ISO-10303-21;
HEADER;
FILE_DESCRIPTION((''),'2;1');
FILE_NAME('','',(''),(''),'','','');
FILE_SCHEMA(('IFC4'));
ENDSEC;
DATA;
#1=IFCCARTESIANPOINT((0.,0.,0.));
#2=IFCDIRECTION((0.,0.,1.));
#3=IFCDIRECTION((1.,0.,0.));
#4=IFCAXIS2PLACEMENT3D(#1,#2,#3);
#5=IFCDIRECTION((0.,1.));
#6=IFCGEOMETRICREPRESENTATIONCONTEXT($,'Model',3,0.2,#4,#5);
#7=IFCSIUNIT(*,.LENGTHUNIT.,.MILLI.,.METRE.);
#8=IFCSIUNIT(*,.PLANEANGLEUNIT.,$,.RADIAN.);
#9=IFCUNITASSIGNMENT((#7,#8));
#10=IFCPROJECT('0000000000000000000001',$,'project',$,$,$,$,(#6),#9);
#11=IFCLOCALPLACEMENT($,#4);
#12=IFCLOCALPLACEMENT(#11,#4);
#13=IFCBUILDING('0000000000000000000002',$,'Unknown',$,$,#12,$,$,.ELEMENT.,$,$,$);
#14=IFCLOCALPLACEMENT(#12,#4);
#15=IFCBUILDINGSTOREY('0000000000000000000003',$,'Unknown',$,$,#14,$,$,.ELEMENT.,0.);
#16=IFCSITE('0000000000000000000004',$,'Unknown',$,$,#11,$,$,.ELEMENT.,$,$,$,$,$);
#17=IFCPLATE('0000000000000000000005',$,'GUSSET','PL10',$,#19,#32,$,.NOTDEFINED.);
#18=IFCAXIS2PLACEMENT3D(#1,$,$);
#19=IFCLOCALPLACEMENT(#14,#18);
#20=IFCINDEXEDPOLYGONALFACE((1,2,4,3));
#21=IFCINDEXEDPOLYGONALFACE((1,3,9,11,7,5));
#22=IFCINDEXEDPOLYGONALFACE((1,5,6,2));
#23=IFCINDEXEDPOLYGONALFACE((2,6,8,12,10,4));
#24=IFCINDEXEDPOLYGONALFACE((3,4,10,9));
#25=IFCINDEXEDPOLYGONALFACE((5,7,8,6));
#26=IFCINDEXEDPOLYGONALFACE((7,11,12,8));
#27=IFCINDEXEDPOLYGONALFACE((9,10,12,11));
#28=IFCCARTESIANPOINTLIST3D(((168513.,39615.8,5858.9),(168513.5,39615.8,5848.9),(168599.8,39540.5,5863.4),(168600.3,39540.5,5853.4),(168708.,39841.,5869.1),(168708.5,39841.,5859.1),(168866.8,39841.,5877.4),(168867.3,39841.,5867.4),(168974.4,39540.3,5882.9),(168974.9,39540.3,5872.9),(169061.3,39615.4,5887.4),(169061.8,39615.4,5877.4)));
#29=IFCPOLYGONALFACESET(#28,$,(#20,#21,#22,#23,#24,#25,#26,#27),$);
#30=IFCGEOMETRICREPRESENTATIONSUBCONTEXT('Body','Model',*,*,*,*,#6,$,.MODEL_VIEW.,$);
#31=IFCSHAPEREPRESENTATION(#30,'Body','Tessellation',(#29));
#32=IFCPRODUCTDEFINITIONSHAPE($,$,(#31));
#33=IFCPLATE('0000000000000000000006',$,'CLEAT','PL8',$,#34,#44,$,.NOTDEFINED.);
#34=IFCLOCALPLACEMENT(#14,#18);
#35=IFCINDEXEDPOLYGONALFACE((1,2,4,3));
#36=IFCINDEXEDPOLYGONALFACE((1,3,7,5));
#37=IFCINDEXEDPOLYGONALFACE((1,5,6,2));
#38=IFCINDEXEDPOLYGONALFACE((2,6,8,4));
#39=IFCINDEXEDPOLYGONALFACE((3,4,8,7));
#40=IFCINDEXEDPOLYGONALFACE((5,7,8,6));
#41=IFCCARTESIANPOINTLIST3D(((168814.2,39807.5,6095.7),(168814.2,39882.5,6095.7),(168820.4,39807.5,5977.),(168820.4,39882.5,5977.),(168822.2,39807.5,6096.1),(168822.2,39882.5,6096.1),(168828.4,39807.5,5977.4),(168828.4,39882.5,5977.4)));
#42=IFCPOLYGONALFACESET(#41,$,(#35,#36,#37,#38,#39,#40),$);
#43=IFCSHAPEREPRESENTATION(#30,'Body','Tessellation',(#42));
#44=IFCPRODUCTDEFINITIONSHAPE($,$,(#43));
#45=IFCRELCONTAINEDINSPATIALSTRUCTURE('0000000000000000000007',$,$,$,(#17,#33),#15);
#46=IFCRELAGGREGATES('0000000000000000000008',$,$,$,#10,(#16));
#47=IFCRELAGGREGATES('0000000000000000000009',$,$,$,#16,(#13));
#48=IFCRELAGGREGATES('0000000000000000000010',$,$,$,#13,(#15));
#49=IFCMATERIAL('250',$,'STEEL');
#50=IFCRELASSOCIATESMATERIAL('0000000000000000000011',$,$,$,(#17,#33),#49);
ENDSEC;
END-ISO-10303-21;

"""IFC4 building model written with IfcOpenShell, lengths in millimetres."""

from ifc_helpers import new_model, si_unit, direction, frame, origin_with_axes, place, context, subcontext, project, spatial, line, indexed_curve, outline, extrude, material, element, save


model = new_model("IFC4")

# Units and contexts
model_context = context("Model", 3, precision=0.2, world=origin_with_axes(), true_north=direction((0.0, 1.0)))
body_context = subcontext(model_context, "Body", "Model", "MODEL_VIEW")
ifc_project = project(units=[si_unit("LENGTHUNIT", "METRE", prefix="MILLI"), si_unit("PLANEANGLEUNIT", "RADIAN")], contexts=[model_context])

# Site, building, storey
site_placement = place(None, origin_with_axes())
site = spatial("IfcSite", under=ifc_project, at=site_placement, Name="Unknown", CompositionType="ELEMENT")
building_placement = place(site_placement, origin_with_axes())
building = spatial("IfcBuilding", under=site, at=building_placement, Name="Unknown", CompositionType="ELEMENT")
storey_placement = place(building_placement, origin_with_axes())
storey = spatial("IfcBuildingStorey", under=building, at=storey_placement, Name="Unknown", CompositionType="ELEMENT", Elevation=0.0)

# Plates
ifc_material_1 = material(Name="250", Category="STEEL")
plate_1_placement = place(storey_placement, frame((168513.2, 39615.8, 5853.9), z_axis=(-0.051972, -0.000229, 0.998649), x_axis=(0.754795, -0.654793, 0.039131)))
element("IfcPlate", 1, at=plate_1_placement, inside=storey, material=ifc_material_1, Name="GUSSET", Description="PL10", PredefinedType="NOTDEFINED", context=body_context, shape_type="SolidModel", body=[
    extrude(outline(indexed_curve([(0.0, 0.0), (115.0, 0.0), (398.6, 245.5), (415.2, 359.2), (120.3, 402.2), (0.1, 298.1)], segments=[line(1, 2, 3, 4, 5, 6, 1)])), frame((0.0, 0.0, 5.0), z_axis=(0.0, 0.0, 1.0), x_axis=(1.0, 0.0, 0.0)), (0.0, 0.0, -1.0), 10.0),
])
plate_2_placement = place(storey_placement, frame((168824.4, 39807.5, 5977.2), z_axis=(0.998639, 0.0, 0.052161), x_axis=(0.0, 1.0, 0.0)))
element("IfcPlate", 2, at=plate_2_placement, inside=storey, material=ifc_material_1, Name="CLEAT", Description="PL8", PredefinedType="NOTDEFINED", context=body_context, shape_type="SolidModel", body=[
    extrude(outline(indexed_curve([(0.0, 0.0), (75.0, 0.0), (75.0, 118.9), (0.0, 118.9)], segments=[line(1, 2, 3, 4, 1)])), frame((0.0, 0.0, 4.0), z_axis=(0.0, 0.0, 1.0), x_axis=(1.0, 0.0, 0.0)), (0.0, 0.0, -1.0), 8.0),
])

save(model, "model.ifc")
